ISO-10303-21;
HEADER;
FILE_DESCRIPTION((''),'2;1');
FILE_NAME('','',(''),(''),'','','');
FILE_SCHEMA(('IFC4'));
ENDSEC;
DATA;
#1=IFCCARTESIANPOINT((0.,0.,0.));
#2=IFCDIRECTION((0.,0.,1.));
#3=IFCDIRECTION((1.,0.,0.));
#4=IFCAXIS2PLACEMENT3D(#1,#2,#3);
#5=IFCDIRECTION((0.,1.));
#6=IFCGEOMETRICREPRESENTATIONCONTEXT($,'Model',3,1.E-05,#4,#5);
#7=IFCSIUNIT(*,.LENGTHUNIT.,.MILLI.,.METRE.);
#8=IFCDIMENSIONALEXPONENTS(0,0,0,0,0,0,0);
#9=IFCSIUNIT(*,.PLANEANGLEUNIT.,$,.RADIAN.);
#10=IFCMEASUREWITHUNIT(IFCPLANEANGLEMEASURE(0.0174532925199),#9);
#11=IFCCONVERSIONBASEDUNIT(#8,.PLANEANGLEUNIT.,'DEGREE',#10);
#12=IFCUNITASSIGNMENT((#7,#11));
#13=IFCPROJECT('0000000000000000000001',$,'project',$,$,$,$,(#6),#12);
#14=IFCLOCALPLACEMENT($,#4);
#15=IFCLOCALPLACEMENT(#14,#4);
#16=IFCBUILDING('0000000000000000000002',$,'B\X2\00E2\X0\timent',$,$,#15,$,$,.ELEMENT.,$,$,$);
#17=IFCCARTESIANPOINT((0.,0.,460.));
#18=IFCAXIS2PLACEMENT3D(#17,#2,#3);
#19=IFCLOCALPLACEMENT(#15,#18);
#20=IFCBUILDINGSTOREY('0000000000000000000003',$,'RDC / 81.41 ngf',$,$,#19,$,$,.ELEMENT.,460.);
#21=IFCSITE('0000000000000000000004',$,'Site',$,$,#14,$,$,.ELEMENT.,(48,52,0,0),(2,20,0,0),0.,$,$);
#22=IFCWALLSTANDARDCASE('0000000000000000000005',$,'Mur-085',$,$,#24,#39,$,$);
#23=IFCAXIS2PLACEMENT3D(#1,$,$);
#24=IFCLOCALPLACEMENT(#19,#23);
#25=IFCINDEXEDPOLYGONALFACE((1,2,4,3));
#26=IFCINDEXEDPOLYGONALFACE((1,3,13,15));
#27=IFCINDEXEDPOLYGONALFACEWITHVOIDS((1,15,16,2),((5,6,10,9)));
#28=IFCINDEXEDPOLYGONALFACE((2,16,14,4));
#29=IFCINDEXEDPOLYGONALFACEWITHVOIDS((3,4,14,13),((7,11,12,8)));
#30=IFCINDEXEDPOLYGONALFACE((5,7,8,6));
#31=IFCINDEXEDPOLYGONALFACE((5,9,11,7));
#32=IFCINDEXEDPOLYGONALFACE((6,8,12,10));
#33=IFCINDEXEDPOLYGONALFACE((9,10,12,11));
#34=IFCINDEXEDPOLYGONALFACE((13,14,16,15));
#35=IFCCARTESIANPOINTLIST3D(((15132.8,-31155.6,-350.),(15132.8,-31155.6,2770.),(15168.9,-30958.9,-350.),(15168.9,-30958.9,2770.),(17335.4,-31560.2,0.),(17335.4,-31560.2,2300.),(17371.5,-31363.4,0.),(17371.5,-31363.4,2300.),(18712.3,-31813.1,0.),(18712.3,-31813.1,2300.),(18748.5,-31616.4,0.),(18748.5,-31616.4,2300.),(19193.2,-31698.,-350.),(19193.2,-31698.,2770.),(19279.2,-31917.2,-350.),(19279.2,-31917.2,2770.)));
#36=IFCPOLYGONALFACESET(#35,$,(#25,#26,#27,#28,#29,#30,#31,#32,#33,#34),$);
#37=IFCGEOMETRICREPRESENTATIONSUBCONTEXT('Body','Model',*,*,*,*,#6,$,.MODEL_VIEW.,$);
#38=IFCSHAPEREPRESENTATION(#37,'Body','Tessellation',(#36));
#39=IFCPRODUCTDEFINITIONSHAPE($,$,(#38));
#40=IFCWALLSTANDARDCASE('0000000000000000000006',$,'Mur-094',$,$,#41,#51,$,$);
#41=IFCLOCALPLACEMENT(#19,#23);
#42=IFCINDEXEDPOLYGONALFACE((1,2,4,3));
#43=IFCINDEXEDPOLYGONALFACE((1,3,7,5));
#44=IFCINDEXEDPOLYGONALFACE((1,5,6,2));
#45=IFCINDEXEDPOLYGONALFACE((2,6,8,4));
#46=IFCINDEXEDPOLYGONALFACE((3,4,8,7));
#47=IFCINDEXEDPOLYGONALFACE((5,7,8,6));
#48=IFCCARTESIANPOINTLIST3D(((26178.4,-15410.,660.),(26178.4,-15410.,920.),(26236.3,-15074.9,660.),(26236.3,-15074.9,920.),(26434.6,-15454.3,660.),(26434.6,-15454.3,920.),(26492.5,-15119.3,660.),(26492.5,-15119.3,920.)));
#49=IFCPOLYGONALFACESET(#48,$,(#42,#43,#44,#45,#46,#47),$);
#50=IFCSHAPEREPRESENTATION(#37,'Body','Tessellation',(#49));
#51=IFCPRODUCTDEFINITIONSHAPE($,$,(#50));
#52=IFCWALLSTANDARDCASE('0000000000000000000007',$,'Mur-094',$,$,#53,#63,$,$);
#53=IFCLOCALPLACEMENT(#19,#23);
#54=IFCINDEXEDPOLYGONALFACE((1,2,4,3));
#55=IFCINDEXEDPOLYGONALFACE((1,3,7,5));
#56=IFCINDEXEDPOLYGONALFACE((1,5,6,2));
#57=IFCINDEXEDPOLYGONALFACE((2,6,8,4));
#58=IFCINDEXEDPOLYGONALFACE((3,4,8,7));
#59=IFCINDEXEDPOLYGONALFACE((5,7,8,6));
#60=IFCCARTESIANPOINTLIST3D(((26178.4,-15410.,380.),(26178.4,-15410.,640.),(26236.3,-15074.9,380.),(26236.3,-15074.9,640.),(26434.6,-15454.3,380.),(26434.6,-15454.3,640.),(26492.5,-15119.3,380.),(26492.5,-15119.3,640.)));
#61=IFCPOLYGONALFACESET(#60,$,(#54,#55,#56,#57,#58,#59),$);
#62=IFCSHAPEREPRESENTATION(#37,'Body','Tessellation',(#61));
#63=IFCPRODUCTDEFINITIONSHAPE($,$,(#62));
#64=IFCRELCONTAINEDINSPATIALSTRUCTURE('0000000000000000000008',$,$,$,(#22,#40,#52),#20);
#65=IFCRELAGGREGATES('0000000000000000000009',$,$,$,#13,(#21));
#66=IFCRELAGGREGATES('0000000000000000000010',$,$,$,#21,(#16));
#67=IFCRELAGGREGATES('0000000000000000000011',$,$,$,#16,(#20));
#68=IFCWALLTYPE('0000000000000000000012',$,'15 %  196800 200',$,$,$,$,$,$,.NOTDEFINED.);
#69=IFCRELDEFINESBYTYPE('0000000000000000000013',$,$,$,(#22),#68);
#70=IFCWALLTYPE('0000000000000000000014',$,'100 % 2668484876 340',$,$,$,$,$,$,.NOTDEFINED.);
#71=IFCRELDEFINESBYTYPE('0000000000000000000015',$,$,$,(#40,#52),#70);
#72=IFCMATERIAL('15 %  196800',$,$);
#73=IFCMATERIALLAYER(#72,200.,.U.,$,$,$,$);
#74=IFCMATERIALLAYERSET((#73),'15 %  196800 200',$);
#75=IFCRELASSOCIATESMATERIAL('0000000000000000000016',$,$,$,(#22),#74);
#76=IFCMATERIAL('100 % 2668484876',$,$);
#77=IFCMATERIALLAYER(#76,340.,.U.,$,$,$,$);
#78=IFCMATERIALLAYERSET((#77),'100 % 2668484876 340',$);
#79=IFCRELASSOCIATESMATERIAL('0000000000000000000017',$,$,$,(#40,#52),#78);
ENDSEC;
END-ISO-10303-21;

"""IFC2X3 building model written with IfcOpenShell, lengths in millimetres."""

from ifc_helpers import new_model, entity, si_unit, converted_unit, direction, frame, origin_with_axes, origin_2d_with_axis, place, context, subcontext, project, spatial, polyline, rectangle, outline, extrude, material, layer, layer_set, layer_usage, type_object, element, save


model = new_model("IFC2X3")

# Units and contexts
model_context = context("Model", 3, precision=1e-05, world=origin_with_axes(), true_north=direction((0.0, 1.0)))
body_context = subcontext(model_context, "Body", "Model", "MODEL_VIEW")
ifc_project = project(units=[si_unit("LENGTHUNIT", "METRE", prefix="MILLI"), converted_unit("PLANEANGLEUNIT", "DEGREE", entity("IfcPlaneAngleMeasure", 0.0174532925199), si_unit("PLANEANGLEUNIT", "RADIAN"), dimensions=[0, 0, 0, 0, 0, 0, 0])], contexts=[model_context])

# Site, building, storey
site_placement = place(None, origin_with_axes())
site = spatial("IfcSite", under=ifc_project, at=site_placement, Name="Site", CompositionType="ELEMENT", RefLatitude=(48, 52, 0, 0), RefLongitude=(2, 20, 0, 0), RefElevation=0.0)
building_placement = place(site_placement, origin_with_axes())
building = spatial("IfcBuilding", under=site, at=building_placement, Name="Bâtiment", CompositionType="ELEMENT")
storey_placement = place(building_placement, frame((0.0, 0.0, 460.0), z_axis=(0.0, 0.0, 1.0), x_axis=(1.0, 0.0, 0.0)))
storey = spatial("IfcBuildingStorey", under=building, at=storey_placement, Name="RDC / 81.41 ngf", CompositionType="ELEMENT", Elevation=460.0)

# Shared definitions
ifc_material_1 = material(Name="15 %  196800")
ifc_material_2 = material(Name="100 % 2668484876")

# Shared definitions
ifc_layer_1 = layer(ifc_material_1, 200.0, ventilated="UNKNOWN")
ifc_layer_set_1 = layer_set([ifc_layer_1], Name="15 %  196800 200")
wall_type_1 = type_object("IfcWallType", Name="15 %  196800 200", PredefinedType="NOTDEFINED")

# Wall, opening
ifc_layer_usage_1 = layer_usage(ifc_layer_set_1, "AXIS2", "POSITIVE", -200.0)
wall_1_placement = place(storey_placement, frame((15168.9, -30958.9, -350.0), z_axis=(0.0, 0.0, 1.0), x_axis=(0.983548, -0.180648, 0.0)))
wall_1 = element("IfcWallStandardCase", 1, at=wall_1_placement, inside=storey, type_object=wall_type_1, material=ifc_layer_usage_1, Name="Mur-085", context=body_context, shape_type="SweptSolid", body=[
    extrude(outline(polyline([(0.0, -200.0), (4215.8, -200.0), (4091.6, 0.0), (0.0, 0.0), (0.0, -200.0)])), origin_with_axes(), (0.0, 0.0, 1.0), 3120.0),
])
opening_1_placement = place(wall_1_placement, frame((2939.5, 0.0, 350.0), z_axis=(0.0, 0.0, 1.0), x_axis=(1.0, 0.0, 0.0)))
element("IfcOpeningElement", 2, at=opening_1_placement, cuts=wall_1, context=body_context, shape_type="SweptSolid", body=[
    extrude(rectangle(XDim=1400.0, YDim=2300.0, at=origin_2d_with_axis()), frame((0.0, -400.0, 1150.0), z_axis=(0.0, -1.0, 0.0), x_axis=(1.0, 0.0, 0.0)), (0.0, 0.0, -1.0), 600.0),
])

# Walls
ifc_layer_2 = layer(ifc_material_2, 340.0, ventilated="UNKNOWN")
ifc_layer_set_2 = layer_set([ifc_layer_2], Name="100 % 2668484876 340")
ifc_layer_usage_2 = layer_usage(ifc_layer_set_2, "AXIS2", "NEGATIVE", 340.0)
wall_type_2 = type_object("IfcWallType", Name="100 % 2668484876 340", PredefinedType="NOTDEFINED")
wall_2_placement = place(storey_placement, frame((26178.4, -15410.0, 660.0), z_axis=(0.0, 0.0, 1.0), x_axis=(0.985365, -0.17046, 0.0)))
element("IfcWallStandardCase", 3, at=wall_2_placement, inside=storey, type_object=wall_type_2, material=ifc_layer_usage_2, Name="Mur-094", context=body_context, shape_type="SweptSolid", body=[
    extrude(outline(polyline([(0.0, 0.0), (260.0, 0.0), (260.0, 340.0), (0.0, 340.0), (0.0, 0.0)])), origin_with_axes(), (0.0, 0.0, 1.0), 260.0),
])
ifc_layer_usage_3 = layer_usage(ifc_layer_set_2, "AXIS2", "NEGATIVE", 340.0)
wall_3_placement = place(storey_placement, frame((26178.4, -15410.0, 380.0), z_axis=(0.0, 0.0, 1.0), x_axis=(0.985365, -0.17046, 0.0)))
element("IfcWallStandardCase", 4, at=wall_3_placement, inside=storey, type_object=wall_type_2, material=ifc_layer_usage_3, Name="Mur-094", context=body_context, shape_type="SweptSolid", body=[
    extrude(outline(polyline([(0.0, 0.0), (260.0, 0.0), (260.0, 340.0), (0.0, 340.0), (0.0, 0.0)])), origin_with_axes(), (0.0, 0.0, 1.0), 260.0),
])

save(model, "model.ifc")
